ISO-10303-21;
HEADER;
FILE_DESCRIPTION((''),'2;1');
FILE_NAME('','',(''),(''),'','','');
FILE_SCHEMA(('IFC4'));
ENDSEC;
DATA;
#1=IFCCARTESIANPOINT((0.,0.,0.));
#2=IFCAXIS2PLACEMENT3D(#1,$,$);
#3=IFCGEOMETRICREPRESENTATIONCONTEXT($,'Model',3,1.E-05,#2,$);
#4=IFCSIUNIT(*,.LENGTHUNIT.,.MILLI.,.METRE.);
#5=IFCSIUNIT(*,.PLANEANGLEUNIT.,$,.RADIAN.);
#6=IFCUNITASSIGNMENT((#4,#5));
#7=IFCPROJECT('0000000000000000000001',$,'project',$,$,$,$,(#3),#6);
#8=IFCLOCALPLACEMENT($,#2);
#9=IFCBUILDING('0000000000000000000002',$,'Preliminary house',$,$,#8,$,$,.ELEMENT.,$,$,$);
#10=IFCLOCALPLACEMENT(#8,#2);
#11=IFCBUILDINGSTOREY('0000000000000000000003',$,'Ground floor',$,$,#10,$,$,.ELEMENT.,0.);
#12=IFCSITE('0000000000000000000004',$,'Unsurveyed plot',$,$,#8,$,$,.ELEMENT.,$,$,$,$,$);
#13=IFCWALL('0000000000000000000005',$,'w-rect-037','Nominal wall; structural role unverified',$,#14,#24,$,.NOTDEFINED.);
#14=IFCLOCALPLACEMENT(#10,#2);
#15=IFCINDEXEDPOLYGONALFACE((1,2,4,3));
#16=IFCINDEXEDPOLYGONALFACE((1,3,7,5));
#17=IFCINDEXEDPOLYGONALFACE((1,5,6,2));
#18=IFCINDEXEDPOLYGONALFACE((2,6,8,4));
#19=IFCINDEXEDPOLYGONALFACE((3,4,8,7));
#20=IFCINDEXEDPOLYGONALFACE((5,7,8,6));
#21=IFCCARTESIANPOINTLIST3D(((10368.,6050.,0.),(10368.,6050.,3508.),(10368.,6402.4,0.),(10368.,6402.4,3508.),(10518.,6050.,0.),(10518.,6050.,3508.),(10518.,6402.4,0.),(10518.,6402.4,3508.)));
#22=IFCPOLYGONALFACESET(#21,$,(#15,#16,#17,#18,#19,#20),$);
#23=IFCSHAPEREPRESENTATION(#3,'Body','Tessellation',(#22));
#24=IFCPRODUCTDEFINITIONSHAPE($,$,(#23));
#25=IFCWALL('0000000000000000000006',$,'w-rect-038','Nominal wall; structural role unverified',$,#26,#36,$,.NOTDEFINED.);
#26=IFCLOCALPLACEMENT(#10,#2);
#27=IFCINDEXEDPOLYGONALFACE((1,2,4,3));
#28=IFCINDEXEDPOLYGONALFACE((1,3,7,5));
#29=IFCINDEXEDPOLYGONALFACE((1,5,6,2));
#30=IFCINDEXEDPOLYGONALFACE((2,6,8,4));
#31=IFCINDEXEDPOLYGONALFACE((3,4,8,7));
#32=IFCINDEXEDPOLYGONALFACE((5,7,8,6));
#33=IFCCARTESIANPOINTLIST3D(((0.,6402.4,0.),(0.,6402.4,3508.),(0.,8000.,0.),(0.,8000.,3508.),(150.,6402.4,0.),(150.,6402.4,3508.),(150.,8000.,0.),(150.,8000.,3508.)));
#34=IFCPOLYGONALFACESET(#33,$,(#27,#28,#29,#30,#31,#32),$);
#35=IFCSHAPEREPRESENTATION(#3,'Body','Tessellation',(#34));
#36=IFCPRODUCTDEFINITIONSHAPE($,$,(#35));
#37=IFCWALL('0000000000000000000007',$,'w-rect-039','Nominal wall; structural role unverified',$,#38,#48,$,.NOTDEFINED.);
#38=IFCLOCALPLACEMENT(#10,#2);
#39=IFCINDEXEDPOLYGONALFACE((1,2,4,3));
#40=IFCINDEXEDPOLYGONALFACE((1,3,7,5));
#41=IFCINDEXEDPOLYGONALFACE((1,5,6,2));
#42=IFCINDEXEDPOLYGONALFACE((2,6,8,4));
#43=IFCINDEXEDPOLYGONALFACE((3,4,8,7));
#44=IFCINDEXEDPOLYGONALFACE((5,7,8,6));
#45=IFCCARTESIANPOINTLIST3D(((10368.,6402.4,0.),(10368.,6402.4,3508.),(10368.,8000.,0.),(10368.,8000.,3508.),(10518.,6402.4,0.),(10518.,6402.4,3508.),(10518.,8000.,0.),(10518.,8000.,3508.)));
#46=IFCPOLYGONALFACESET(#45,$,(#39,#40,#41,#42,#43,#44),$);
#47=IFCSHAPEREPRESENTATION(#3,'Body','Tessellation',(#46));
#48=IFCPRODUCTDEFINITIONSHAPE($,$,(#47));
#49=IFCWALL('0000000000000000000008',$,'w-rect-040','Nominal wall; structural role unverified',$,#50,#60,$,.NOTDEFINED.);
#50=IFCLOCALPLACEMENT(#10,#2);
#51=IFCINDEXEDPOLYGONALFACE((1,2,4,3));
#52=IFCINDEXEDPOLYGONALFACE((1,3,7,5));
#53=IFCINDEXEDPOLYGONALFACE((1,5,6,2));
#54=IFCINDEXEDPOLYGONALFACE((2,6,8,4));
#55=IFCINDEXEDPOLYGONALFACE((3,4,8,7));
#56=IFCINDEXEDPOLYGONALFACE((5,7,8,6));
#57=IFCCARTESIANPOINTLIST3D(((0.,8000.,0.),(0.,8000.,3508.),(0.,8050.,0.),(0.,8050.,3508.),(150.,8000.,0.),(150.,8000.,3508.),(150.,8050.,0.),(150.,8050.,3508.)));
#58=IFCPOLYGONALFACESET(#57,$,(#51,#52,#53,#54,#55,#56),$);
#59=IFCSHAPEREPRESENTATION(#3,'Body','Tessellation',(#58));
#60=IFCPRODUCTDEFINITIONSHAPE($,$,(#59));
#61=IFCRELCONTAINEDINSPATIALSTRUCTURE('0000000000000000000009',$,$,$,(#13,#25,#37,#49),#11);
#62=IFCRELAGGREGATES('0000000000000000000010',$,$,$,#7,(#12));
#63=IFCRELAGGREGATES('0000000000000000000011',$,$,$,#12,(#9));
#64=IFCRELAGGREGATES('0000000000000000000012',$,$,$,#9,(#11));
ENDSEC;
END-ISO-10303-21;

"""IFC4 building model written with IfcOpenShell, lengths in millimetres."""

from ifc_helpers import new_model, si_unit, origin, place, context, project, spatial, polyline, outline, extrude, element, save


model = new_model("IFC4")

# Units and contexts
model_context = context("Model", 3, precision=1e-05, world=origin())
ifc_project = project(units=[si_unit("LENGTHUNIT", "METRE", prefix="MILLI"), si_unit("PLANEANGLEUNIT", "RADIAN")], contexts=[model_context])

# Site, building, storey
placement_1 = place(None, origin())
site = spatial("IfcSite", under=ifc_project, at=placement_1, Name="Unsurveyed plot", CompositionType="ELEMENT")
building = spatial("IfcBuilding", under=site, at=placement_1, Name="Preliminary house", CompositionType="ELEMENT")
placement_2 = place(placement_1, origin())
storey = spatial("IfcBuildingStorey", under=building, at=placement_2, Name="Ground floor", CompositionType="ELEMENT", Elevation=0.0)

# Walls
element("IfcWall", 1, at=placement_2, inside=storey, Name="w-rect-037", Description="Nominal wall; structural role unverified", PredefinedType="NOTDEFINED", context=model_context, shape_type="SweptSolid", body=[
    extrude(outline(polyline([(10368.0, 6050.0), (10518.0, 6050.0), (10518.0, 6402.4), (10368.0, 6402.4), (10368.0, 6050.0)])), origin(), (0.0, 0.0, 1.0), 3508.0),
])
element("IfcWall", 2, at=placement_2, inside=storey, Name="w-rect-038", Description="Nominal wall; structural role unverified", PredefinedType="NOTDEFINED", context=model_context, shape_type="SweptSolid", body=[
    extrude(outline(polyline([(0.0, 6402.4), (150.0, 6402.4), (150.0, 8000.0), (0.0, 8000.0), (0.0, 6402.4)])), origin(), (0.0, 0.0, 1.0), 3508.0),
])
element("IfcWall", 3, at=placement_2, inside=storey, Name="w-rect-039", Description="Nominal wall; structural role unverified", PredefinedType="NOTDEFINED", context=model_context, shape_type="SweptSolid", body=[
    extrude(outline(polyline([(10368.0, 6402.4), (10518.0, 6402.4), (10518.0, 8000.0), (10368.0, 8000.0), (10368.0, 6402.4)])), origin(), (0.0, 0.0, 1.0), 3508.0),
])
element("IfcWall", 4, at=placement_2, inside=storey, Name="w-rect-040", Description="Nominal wall; structural role unverified", PredefinedType="NOTDEFINED", context=model_context, shape_type="SweptSolid", body=[
    extrude(outline(polyline([(0.0, 8000.0), (150.0, 8000.0), (150.0, 8050.0), (0.0, 8050.0), (0.0, 8000.0)])), origin(), (0.0, 0.0, 1.0), 3508.0),
])

save(model, "model.ifc")
